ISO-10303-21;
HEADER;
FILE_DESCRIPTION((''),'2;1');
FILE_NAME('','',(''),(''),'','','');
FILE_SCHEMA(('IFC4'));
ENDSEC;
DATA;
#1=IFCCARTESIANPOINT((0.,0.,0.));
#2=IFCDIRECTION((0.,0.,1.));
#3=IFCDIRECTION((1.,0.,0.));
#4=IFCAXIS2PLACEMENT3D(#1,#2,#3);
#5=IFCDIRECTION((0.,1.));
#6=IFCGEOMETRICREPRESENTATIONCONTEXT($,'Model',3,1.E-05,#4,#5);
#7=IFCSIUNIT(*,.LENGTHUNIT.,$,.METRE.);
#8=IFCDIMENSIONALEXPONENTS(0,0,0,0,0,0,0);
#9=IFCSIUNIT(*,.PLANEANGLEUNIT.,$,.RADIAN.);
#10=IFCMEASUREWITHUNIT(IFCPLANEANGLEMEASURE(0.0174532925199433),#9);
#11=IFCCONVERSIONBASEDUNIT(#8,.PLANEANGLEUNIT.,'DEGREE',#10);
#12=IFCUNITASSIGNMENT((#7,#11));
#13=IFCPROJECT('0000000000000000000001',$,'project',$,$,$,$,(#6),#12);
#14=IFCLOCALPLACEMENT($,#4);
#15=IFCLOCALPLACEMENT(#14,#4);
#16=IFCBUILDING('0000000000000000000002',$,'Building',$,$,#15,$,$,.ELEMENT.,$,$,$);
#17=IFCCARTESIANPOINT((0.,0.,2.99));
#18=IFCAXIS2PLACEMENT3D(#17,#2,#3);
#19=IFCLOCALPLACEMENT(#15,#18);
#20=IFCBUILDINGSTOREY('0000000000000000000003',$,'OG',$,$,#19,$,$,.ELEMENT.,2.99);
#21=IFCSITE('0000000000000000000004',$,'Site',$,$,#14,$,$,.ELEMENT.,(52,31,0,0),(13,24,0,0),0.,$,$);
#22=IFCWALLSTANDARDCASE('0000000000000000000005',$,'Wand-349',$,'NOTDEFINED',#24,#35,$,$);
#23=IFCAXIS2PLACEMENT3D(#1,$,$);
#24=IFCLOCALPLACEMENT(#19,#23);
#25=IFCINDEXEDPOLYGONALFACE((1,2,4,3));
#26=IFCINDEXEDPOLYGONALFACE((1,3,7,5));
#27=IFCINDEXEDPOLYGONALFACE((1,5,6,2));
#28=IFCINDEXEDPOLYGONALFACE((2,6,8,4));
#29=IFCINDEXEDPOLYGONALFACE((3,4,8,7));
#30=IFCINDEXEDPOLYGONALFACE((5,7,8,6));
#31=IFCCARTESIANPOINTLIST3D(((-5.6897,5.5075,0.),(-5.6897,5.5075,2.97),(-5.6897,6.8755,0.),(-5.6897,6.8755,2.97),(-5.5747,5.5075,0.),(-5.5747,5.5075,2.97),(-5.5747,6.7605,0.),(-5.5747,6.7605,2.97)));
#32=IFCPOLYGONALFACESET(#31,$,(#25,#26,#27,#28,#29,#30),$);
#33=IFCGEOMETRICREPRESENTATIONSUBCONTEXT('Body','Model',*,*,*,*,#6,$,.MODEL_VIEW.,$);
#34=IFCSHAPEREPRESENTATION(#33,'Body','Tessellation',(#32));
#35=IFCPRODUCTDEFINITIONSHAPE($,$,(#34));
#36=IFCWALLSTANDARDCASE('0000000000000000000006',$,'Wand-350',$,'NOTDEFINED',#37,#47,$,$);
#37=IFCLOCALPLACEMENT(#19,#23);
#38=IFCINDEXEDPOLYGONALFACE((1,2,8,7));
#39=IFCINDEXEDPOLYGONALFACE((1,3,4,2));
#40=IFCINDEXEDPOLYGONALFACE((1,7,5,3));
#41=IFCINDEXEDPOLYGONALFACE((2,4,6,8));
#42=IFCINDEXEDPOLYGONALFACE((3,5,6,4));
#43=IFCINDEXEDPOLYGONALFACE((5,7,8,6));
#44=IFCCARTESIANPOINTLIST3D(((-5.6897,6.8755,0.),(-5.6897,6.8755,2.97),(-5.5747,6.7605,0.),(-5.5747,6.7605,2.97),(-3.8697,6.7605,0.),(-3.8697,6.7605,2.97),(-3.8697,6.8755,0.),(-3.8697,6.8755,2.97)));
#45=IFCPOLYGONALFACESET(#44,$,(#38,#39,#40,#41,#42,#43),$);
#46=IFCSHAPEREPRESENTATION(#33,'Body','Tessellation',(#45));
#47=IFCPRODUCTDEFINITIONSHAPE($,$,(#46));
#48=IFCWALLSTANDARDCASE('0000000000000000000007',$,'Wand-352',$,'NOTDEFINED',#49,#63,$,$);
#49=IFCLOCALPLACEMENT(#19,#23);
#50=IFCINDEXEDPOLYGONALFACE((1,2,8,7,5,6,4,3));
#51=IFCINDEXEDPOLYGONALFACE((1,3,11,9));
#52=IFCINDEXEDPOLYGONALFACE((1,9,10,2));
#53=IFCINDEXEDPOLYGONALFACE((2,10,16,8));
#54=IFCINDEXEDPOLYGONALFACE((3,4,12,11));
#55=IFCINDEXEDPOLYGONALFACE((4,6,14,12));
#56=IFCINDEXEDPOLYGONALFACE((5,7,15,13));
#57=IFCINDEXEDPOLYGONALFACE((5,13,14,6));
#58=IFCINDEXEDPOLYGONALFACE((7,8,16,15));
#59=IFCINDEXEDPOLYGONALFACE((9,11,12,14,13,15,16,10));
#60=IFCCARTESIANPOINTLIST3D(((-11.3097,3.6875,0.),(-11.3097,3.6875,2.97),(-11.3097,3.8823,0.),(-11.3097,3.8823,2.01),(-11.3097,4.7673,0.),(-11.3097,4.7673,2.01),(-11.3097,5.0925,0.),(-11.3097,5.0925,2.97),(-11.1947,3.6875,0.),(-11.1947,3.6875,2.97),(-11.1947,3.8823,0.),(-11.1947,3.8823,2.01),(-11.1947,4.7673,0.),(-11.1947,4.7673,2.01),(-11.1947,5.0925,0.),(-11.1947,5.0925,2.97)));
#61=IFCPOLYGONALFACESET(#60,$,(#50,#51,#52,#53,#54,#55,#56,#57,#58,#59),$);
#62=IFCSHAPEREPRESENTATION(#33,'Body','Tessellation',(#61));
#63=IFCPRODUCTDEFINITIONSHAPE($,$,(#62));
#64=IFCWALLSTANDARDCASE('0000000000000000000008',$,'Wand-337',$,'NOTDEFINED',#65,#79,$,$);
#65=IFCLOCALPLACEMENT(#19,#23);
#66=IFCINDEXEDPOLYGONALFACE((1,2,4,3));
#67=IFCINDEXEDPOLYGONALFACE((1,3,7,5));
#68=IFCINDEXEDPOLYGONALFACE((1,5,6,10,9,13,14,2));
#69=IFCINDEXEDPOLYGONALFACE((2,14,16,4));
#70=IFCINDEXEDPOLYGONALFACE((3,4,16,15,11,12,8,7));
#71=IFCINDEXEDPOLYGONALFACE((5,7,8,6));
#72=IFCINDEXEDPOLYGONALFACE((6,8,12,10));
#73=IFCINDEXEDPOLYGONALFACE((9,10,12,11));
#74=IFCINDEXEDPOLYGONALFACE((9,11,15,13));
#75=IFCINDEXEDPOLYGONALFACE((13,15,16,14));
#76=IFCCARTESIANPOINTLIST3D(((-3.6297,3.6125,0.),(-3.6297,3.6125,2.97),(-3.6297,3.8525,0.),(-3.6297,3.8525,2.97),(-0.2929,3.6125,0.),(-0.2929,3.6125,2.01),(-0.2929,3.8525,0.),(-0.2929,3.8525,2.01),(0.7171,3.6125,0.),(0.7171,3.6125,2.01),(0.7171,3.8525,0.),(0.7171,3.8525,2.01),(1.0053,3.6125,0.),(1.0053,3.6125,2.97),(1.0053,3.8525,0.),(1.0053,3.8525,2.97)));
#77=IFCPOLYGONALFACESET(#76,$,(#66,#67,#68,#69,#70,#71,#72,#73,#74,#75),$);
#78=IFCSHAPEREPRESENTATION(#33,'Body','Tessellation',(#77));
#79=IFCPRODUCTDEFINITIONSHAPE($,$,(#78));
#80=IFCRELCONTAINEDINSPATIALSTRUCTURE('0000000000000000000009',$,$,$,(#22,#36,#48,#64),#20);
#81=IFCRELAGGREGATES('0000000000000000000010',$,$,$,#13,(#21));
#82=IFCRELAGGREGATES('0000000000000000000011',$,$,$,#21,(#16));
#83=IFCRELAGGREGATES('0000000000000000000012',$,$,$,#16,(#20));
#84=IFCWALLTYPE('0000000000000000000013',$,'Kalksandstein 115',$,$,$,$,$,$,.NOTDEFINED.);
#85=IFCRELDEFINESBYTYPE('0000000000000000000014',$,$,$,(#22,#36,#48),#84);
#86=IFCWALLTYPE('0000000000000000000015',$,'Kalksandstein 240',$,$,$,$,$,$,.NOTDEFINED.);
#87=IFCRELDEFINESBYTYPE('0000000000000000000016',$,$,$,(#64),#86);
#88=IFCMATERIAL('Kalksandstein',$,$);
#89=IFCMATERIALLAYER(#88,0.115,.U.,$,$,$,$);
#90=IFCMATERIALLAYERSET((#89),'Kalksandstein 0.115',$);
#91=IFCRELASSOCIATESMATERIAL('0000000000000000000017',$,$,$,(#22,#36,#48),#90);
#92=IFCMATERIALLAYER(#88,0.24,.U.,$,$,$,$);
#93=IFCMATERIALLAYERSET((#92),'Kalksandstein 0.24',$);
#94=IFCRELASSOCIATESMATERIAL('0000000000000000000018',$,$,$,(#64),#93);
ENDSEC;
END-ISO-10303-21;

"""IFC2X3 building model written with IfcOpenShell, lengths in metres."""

from ifc_helpers import new_model, entity, si_unit, converted_unit, direction, frame, origin_with_axes, origin_2d_with_axis, place, context, subcontext, project, spatial, polyline, rectangle, outline, extrude, material, layer, layer_set, layer_usage, type_object, element, save


model = new_model("IFC2X3")

# Units and contexts
model_context = context("Model", 3, precision=1e-05, world=origin_with_axes(), true_north=direction((0.0, 1.0)))
body_context = subcontext(model_context, "Body", "Model", "MODEL_VIEW")
ifc_project = project(units=[si_unit("LENGTHUNIT", "METRE"), converted_unit("PLANEANGLEUNIT", "DEGREE", entity("IfcPlaneAngleMeasure", 0.0174532925199433), si_unit("PLANEANGLEUNIT", "RADIAN"), dimensions=[0, 0, 0, 0, 0, 0, 0])], contexts=[model_context])

# Site, building, storey
site_placement = place(None, origin_with_axes())
site = spatial("IfcSite", under=ifc_project, at=site_placement, Name="Site", CompositionType="ELEMENT", RefLatitude=(52, 31, 0, 0), RefLongitude=(13, 24, 0, 0), RefElevation=0.0)
building_placement = place(site_placement, origin_with_axes())
building = spatial("IfcBuilding", under=site, at=building_placement, Name="Building", CompositionType="ELEMENT")
storey_placement = place(building_placement, frame((0.0, 0.0, 2.99), z_axis=(0.0, 0.0, 1.0), x_axis=(1.0, 0.0, 0.0)))
storey = spatial("IfcBuildingStorey", under=building, at=storey_placement, Name="OG", CompositionType="ELEMENT", Elevation=2.99)

# Shared definitions
ifc_material_1 = material(Name="Kalksandstein")

# Shared definitions
ifc_layer_1 = layer(ifc_material_1, 0.115, ventilated="UNKNOWN")
ifc_layer_set_1 = layer_set([ifc_layer_1], Name="Kalksandstein 0.115")
wall_type_1 = type_object("IfcWallType", Name="Kalksandstein 115", PredefinedType="NOTDEFINED")

# Wall
ifc_layer_usage_1 = layer_usage(ifc_layer_set_1, "AXIS2", "NEGATIVE", 0.115)
wall_1_placement = place(storey_placement, frame((-5.5747, 5.5075, 0.0), z_axis=(0.0, 0.0, 1.0), x_axis=(0.0, 1.0, 0.0)))
element("IfcWallStandardCase", 1, at=wall_1_placement, inside=storey, type_object=wall_type_1, material=ifc_layer_usage_1, Name="Wand-349", ObjectType="NOTDEFINED", context=body_context, shape_type="SweptSolid", body=[
    extrude(outline(polyline([(0.0, 0.0), (1.253, 0.0), (1.368, 0.115), (0.0, 0.115), (0.0, 0.0)])), origin_with_axes(), (0.0, 0.0, 1.0), 2.97),
])

# Wall
ifc_layer_usage_2 = layer_usage(ifc_layer_set_1, "AXIS2", "NEGATIVE", 0.115)
wall_2_placement = place(storey_placement, frame((-5.5747, 6.7605, 0.0), z_axis=(0.0, 0.0, 1.0), x_axis=(1.0, 0.0, 0.0)))
element("IfcWallStandardCase", 2, at=wall_2_placement, inside=storey, type_object=wall_type_1, material=ifc_layer_usage_2, Name="Wand-350", ObjectType="NOTDEFINED", context=body_context, shape_type="SweptSolid", body=[
    extrude(outline(polyline([(0.0, 0.0), (1.705, 0.0), (1.705, 0.115), (-0.115, 0.115), (0.0, 0.0)])), origin_with_axes(), (0.0, 0.0, 1.0), 2.97),
])

# Wall, opening
ifc_layer_usage_3 = layer_usage(ifc_layer_set_1, "AXIS2", "NEGATIVE", 0.115)
wall_3_placement = place(storey_placement, frame((-11.3097, 5.0925, 0.0), z_axis=(0.0, 0.0, 1.0), x_axis=(0.0, -1.0, 0.0)))
wall_3 = element("IfcWallStandardCase", 3, at=wall_3_placement, inside=storey, type_object=wall_type_1, material=ifc_layer_usage_3, Name="Wand-352", ObjectType="NOTDEFINED", context=body_context, shape_type="SweptSolid", body=[
    extrude(outline(polyline([(0.0, 0.0), (1.405, 0.0), (1.405, 0.115), (0.0, 0.115), (0.0, 0.0)])), origin_with_axes(), (0.0, 0.0, 1.0), 2.97),
])
opening_1_placement = place(wall_3_placement, frame((0.7677, 0.0, 0.0), z_axis=(0.0, 0.0, 1.0), x_axis=(1.0, 0.0, 0.0)))
element("IfcOpeningElement", 4, at=opening_1_placement, cuts=wall_3, context=body_context, shape_type="SweptSolid", body=[
    extrude(rectangle(XDim=0.885, YDim=2.01, at=origin_2d_with_axis()), frame((0.0, -0.115, 1.005), z_axis=(0.0, 1.0, 0.0), x_axis=(1.0, 0.0, 0.0)), (0.0, 0.0, 1.0), 0.345),
])

# Wall, opening
ifc_layer_2 = layer(ifc_material_1, 0.24, ventilated="UNKNOWN")
ifc_layer_set_2 = layer_set([ifc_layer_2], Name="Kalksandstein 0.24")
wall_type_2 = type_object("IfcWallType", Name="Kalksandstein 240", PredefinedType="NOTDEFINED")
ifc_layer_usage_4 = layer_usage(ifc_layer_set_2, "AXIS2", "NEGATIVE", 0.24)
wall_4_placement = place(storey_placement, frame((-3.6297, 3.6125, 0.0), z_axis=(0.0, 0.0, 1.0), x_axis=(1.0, 0.0, 0.0)))
wall_4 = element("IfcWallStandardCase", 5, at=wall_4_placement, inside=storey, type_object=wall_type_2, material=ifc_layer_usage_4, Name="Wand-337", ObjectType="NOTDEFINED", context=body_context, shape_type="SweptSolid", body=[
    extrude(outline(polyline([(0.0, 0.0), (4.635, 0.0), (4.635, 0.24), (0.0, 0.24), (0.0, 0.0)])), origin_with_axes(), (0.0, 0.0, 1.0), 2.97),
])
opening_2_placement = place(wall_4_placement, frame((3.8418, 0.0, 0.0), z_axis=(0.0, 0.0, 1.0), x_axis=(1.0, 0.0, 0.0)))
element("IfcOpeningElement", 6, at=opening_2_placement, cuts=wall_4, context=body_context, shape_type="SweptSolid", body=[
    extrude(rectangle(XDim=1.01, YDim=2.01, at=origin_2d_with_axis()), frame((0.0, 0.24, 1.005), z_axis=(0.0, 1.0, 0.0), x_axis=(1.0, 0.0, 0.0)), (0.0, 0.0, -1.0), 0.72),
])

save(model, "model.ifc")
